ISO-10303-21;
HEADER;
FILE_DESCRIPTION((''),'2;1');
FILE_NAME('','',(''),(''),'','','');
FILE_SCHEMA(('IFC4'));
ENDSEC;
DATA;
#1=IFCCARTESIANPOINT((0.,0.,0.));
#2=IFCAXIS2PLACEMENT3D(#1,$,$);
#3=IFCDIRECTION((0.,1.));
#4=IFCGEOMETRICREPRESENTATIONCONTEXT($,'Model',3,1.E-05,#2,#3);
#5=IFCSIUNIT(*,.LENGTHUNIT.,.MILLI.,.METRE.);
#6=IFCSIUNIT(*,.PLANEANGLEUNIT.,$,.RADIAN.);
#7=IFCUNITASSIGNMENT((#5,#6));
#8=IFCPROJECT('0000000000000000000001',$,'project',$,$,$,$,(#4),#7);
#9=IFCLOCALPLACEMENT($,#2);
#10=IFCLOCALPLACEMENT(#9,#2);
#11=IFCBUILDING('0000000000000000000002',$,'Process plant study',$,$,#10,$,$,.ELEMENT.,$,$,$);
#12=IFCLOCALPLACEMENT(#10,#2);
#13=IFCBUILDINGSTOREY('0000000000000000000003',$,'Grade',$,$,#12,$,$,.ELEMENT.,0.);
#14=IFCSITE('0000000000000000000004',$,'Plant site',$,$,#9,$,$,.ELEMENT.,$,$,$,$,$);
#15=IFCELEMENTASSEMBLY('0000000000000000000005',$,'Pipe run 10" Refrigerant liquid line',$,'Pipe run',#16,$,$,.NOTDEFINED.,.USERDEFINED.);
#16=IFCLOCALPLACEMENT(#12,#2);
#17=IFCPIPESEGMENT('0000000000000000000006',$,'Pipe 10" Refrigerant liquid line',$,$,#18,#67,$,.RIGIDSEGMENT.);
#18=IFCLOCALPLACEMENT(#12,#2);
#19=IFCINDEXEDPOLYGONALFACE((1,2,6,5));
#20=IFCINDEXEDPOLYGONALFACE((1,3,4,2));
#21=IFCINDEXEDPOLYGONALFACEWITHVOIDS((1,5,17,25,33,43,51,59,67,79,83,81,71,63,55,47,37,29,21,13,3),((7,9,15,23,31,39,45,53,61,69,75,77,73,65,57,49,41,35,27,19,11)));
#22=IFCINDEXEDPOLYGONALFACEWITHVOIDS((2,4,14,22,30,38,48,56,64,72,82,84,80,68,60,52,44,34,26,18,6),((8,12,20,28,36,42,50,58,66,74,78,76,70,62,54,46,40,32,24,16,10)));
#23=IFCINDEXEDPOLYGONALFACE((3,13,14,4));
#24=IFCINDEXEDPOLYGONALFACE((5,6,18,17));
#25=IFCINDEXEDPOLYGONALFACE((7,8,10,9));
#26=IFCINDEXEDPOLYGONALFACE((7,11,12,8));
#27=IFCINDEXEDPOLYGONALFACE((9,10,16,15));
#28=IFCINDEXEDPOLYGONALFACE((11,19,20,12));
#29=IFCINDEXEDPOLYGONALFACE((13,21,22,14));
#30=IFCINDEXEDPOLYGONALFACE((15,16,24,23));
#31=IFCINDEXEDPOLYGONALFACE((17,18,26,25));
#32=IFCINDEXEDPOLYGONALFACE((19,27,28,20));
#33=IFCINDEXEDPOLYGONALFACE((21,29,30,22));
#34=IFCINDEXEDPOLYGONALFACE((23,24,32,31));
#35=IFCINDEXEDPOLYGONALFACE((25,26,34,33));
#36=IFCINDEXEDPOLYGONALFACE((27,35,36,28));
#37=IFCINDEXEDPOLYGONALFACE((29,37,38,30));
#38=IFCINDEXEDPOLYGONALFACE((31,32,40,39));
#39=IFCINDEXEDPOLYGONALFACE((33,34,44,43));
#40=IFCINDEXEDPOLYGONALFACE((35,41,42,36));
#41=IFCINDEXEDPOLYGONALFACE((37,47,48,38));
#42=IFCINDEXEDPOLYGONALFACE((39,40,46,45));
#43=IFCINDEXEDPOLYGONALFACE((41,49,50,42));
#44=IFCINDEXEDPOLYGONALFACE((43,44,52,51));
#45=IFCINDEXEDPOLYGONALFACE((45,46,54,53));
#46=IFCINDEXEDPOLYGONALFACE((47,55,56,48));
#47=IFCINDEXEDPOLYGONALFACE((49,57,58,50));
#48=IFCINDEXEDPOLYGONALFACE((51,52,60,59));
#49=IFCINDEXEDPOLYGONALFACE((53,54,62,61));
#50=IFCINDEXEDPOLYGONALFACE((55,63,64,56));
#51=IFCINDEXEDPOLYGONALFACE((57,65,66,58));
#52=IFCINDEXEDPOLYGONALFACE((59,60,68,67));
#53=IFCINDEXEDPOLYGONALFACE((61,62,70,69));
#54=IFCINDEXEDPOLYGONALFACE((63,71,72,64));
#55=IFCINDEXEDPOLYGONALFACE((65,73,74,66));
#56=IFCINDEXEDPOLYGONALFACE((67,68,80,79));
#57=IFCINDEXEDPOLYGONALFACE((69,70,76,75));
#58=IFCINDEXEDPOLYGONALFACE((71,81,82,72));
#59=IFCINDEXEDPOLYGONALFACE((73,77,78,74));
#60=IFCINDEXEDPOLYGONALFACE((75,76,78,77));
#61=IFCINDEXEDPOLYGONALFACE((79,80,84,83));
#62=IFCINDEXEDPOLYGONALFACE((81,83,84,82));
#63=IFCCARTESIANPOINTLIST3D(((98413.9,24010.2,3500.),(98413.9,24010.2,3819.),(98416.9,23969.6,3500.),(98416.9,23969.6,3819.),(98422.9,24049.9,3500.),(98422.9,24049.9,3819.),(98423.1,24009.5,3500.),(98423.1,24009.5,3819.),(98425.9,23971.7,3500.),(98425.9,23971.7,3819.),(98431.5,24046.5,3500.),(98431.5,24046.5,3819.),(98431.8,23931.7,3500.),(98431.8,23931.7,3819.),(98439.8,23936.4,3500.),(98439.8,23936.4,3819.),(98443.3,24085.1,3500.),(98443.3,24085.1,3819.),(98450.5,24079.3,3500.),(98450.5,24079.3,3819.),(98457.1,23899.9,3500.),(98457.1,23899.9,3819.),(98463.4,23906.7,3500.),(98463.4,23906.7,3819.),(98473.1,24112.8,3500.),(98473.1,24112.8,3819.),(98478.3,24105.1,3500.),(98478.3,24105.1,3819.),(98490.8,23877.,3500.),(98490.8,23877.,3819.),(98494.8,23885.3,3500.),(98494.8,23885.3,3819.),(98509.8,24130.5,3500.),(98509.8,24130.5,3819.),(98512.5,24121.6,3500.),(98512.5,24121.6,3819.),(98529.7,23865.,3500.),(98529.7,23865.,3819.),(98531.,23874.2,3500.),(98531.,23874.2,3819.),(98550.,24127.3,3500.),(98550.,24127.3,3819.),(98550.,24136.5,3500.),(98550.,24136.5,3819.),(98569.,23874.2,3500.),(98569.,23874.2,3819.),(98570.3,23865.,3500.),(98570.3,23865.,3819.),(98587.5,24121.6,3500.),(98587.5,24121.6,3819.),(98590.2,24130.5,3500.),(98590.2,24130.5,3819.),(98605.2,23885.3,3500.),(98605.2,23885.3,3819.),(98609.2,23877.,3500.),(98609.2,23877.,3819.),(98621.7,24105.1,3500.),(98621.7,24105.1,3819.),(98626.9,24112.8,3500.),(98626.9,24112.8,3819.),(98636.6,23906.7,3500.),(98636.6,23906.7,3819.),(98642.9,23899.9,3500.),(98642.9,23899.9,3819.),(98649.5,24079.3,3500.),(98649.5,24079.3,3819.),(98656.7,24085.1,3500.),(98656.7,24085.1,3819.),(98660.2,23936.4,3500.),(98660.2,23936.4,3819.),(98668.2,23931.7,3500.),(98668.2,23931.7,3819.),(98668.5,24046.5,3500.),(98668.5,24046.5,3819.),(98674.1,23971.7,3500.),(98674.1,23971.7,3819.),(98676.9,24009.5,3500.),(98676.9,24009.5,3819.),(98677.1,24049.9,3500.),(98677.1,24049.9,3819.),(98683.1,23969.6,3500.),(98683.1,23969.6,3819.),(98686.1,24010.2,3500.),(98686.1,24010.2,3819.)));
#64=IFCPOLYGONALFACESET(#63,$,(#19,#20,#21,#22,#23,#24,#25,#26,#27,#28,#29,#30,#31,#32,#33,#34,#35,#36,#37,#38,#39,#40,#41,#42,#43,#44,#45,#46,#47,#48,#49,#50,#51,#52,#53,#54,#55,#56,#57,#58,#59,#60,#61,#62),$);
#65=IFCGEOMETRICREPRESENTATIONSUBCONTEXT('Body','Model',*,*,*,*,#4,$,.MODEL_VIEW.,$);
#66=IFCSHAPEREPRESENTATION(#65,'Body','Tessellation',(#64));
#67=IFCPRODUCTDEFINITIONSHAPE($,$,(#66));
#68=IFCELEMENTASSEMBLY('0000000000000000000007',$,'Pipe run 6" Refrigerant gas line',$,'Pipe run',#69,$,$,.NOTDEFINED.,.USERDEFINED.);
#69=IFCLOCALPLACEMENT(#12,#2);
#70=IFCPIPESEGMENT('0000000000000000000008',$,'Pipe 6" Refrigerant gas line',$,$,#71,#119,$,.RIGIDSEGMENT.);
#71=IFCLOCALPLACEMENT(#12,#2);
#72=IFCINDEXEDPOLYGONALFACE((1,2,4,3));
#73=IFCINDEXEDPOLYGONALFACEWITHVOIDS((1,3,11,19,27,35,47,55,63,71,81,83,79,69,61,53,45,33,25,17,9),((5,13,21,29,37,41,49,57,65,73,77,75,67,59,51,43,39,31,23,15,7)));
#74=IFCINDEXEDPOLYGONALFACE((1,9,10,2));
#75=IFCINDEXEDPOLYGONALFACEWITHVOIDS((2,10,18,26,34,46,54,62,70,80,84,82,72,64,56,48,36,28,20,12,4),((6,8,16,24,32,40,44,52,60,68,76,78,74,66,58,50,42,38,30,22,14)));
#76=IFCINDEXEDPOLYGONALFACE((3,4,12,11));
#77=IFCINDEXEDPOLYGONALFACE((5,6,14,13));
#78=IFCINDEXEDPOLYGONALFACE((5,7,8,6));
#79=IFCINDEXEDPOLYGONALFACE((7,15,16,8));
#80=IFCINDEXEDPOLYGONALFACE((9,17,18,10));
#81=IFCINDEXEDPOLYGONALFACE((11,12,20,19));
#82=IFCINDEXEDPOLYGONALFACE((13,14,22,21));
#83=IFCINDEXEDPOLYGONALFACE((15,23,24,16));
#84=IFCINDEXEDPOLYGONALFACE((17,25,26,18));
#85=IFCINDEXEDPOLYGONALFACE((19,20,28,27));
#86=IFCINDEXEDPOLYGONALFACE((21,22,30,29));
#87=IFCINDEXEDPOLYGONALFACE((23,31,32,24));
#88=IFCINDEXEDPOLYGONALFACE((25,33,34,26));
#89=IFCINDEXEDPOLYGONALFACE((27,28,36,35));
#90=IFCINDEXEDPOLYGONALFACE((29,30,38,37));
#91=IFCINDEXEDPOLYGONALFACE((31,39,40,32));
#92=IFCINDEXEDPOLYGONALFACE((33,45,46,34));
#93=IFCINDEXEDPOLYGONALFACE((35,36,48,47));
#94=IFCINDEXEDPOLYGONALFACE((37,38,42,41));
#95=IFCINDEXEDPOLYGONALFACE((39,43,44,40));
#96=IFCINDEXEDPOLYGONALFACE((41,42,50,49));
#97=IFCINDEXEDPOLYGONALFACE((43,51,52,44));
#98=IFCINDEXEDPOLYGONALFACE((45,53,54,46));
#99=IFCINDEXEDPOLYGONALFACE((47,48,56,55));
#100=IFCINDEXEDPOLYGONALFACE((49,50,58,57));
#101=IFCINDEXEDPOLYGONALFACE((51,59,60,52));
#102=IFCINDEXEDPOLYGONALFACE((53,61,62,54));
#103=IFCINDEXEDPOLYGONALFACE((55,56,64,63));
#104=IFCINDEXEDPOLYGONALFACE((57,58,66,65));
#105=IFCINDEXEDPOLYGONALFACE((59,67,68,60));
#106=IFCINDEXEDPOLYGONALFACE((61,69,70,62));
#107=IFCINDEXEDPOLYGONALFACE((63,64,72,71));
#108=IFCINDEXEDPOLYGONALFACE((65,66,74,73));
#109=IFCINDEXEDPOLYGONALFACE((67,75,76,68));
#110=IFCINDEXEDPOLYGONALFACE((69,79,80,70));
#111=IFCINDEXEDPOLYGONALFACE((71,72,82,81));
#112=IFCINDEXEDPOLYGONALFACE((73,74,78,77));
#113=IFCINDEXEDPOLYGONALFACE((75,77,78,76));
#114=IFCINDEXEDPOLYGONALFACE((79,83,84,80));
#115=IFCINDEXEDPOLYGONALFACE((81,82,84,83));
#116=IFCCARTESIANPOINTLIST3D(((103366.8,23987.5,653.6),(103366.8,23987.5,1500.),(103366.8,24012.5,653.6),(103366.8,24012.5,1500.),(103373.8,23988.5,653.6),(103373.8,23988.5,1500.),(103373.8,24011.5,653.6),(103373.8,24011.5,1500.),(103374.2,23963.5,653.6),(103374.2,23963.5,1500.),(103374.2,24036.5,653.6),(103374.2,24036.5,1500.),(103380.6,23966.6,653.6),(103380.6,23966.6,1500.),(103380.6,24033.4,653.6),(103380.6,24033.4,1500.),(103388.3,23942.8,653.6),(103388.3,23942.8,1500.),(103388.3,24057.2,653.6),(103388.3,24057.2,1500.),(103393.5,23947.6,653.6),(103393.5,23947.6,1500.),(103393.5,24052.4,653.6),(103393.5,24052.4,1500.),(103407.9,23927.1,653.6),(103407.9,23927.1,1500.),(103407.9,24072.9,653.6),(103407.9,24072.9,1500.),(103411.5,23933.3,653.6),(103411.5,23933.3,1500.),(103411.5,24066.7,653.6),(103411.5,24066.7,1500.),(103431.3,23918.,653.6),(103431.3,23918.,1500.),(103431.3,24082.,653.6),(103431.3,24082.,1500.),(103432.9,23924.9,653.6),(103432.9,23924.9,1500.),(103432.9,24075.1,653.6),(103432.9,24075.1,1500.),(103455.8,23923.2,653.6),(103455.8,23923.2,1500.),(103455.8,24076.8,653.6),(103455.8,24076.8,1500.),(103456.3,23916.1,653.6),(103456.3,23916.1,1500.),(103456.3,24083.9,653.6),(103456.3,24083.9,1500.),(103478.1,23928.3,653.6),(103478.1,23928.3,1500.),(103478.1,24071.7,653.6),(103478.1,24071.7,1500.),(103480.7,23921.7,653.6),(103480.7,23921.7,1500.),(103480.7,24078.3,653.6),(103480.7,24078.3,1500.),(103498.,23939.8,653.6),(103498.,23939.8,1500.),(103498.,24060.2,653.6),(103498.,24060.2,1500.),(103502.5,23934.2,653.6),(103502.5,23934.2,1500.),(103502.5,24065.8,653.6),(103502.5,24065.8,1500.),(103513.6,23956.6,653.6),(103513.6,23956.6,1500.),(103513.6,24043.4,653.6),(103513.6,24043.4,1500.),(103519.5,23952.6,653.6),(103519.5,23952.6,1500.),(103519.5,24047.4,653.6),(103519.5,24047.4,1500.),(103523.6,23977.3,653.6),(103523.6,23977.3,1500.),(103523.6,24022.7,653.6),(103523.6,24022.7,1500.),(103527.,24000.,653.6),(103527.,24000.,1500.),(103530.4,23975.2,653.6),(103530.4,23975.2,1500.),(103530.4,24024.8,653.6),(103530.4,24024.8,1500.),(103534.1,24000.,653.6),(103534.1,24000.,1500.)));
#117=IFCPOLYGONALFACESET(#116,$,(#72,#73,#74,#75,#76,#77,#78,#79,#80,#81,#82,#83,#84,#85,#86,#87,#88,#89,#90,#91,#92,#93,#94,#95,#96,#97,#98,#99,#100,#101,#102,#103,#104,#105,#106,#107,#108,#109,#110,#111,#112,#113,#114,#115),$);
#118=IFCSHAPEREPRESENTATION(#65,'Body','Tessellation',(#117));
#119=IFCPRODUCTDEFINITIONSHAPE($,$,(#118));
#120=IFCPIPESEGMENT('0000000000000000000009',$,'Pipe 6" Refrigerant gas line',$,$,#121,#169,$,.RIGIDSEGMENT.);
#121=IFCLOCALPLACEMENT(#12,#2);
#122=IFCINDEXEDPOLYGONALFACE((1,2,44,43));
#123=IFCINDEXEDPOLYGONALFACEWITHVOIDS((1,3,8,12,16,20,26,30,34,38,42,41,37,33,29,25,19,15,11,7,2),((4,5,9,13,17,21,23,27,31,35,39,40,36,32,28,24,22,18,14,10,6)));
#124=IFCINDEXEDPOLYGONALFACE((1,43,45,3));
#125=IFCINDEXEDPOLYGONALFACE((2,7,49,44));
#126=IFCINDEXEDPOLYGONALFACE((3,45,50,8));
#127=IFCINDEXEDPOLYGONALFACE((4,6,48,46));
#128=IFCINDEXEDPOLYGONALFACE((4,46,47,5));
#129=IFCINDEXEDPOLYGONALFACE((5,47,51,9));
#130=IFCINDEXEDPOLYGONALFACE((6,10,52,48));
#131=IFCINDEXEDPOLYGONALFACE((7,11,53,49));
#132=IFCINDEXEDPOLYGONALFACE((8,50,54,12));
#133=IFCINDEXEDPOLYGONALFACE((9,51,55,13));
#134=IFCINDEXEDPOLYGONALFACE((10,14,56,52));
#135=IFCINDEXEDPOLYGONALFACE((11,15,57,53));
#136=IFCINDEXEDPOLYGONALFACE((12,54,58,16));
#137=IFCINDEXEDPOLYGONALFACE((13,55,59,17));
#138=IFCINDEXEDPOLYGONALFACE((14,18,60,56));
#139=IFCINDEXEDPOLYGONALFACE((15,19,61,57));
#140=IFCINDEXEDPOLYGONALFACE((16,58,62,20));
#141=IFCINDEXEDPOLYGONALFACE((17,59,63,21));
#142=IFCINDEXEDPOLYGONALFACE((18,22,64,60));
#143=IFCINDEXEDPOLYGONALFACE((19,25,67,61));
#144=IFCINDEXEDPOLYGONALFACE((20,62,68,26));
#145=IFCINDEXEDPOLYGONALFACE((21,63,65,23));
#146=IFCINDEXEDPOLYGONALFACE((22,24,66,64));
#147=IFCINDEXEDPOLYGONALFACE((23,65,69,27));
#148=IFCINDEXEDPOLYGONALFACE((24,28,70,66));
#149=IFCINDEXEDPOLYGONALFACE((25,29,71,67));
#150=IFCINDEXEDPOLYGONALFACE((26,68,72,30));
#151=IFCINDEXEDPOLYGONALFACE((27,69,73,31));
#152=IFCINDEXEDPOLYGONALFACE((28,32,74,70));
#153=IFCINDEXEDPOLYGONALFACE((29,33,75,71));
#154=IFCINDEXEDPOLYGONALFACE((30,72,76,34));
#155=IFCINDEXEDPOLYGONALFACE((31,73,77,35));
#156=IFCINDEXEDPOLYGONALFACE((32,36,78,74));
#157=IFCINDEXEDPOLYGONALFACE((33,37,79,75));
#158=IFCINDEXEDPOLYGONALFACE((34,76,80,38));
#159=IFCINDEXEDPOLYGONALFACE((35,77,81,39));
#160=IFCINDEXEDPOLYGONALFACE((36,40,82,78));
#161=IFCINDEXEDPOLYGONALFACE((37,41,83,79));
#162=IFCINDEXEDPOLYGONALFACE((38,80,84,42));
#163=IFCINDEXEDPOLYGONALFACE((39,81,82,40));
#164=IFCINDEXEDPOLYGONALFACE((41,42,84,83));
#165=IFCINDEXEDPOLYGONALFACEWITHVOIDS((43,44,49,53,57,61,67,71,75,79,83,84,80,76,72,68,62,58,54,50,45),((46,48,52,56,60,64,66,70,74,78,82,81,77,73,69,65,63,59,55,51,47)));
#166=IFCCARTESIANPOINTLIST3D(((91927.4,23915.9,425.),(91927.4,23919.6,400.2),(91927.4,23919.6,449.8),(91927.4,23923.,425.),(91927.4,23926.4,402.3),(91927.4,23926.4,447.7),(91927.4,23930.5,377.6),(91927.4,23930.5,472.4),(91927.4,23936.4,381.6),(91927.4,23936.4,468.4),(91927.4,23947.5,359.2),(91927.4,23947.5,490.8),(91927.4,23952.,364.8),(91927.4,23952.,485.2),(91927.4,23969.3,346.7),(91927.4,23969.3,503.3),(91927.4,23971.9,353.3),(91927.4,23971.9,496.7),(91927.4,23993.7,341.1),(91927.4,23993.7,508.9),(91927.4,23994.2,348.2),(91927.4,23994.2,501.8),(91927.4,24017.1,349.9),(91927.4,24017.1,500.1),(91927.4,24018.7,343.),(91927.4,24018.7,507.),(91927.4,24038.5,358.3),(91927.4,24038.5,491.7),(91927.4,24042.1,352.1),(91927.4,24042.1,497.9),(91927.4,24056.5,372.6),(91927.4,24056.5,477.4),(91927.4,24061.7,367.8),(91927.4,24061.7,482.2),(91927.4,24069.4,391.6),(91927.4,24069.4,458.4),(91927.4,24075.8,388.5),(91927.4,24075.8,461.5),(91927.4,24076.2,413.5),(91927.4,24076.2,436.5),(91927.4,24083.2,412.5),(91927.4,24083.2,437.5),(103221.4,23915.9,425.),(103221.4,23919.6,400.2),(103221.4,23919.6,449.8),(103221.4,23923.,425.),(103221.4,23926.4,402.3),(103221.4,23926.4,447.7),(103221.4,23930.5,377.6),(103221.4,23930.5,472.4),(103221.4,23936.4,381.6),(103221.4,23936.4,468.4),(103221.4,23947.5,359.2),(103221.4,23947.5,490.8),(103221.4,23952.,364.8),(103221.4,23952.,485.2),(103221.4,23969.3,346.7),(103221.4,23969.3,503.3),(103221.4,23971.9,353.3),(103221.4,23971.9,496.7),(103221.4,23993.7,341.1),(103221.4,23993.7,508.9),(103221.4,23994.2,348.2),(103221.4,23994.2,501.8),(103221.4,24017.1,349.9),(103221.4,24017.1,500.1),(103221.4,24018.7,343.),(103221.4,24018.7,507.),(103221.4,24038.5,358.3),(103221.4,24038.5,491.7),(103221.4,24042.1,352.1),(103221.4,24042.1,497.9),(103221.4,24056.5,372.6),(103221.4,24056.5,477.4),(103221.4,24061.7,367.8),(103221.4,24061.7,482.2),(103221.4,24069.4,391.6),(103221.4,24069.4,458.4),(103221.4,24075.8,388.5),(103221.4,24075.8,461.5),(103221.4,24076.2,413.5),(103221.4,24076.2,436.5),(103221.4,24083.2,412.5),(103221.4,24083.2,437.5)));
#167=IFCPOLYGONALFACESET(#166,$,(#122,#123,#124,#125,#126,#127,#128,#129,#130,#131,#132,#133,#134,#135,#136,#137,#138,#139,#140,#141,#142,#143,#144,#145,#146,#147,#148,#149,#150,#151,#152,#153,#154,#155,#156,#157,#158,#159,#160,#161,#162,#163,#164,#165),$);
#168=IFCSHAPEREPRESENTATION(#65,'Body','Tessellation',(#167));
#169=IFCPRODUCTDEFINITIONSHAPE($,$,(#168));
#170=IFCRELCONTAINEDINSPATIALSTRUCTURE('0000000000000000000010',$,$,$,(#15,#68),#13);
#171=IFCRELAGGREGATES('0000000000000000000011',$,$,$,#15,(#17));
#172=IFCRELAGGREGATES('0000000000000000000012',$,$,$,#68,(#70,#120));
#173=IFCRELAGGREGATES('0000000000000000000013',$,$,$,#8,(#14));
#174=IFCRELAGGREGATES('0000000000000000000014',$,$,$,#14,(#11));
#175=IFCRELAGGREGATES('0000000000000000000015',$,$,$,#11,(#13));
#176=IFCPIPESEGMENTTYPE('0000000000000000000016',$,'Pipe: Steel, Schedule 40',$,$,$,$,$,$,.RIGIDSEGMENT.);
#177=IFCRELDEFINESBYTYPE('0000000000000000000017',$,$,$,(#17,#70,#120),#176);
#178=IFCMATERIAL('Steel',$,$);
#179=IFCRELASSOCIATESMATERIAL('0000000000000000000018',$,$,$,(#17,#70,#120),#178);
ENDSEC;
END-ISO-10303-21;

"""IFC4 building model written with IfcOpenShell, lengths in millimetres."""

from ifc_helpers import new_model, si_unit, direction, frame, origin, origin_with_axes, origin_2d, place, context, subcontext, project, spatial, hollow_circle, extrude, material, type_object, element, aggregate, save


model = new_model("IFC4")

# Units and contexts
model_context = context("Model", 3, precision=1e-05, world=origin(), true_north=direction((0.0, 1.0)))
body_context = subcontext(model_context, "Body", "Model", "MODEL_VIEW")
ifc_project = project(units=[si_unit("LENGTHUNIT", "METRE", prefix="MILLI"), si_unit("PLANEANGLEUNIT", "RADIAN")], contexts=[model_context])

# Site, building, storey
site_placement = place(None, origin())
site = spatial("IfcSite", under=ifc_project, at=site_placement, Name="Plant site", CompositionType="ELEMENT")
building_placement = place(site_placement, origin())
building = spatial("IfcBuilding", under=site, at=building_placement, Name="Process plant study", CompositionType="ELEMENT")
storey_placement = place(building_placement, origin())
storey = spatial("IfcBuildingStorey", under=building, at=storey_placement, Name="Grade", CompositionType="ELEMENT", Elevation=0.0)

# Element assemblies, pipe segments
assembly_1_placement = place(storey_placement, origin_with_axes())
assembly_1 = element("IfcElementAssembly", 1, at=assembly_1_placement, inside=storey, Name="Pipe run 10\" Refrigerant liquid line", ObjectType="Pipe run", AssemblyPlace="NOTDEFINED", PredefinedType="USERDEFINED")
ifc_material = material(Name="Steel")
pipe_segment_type = type_object("IfcPipeSegmentType", Name="Pipe: Steel, Schedule 40", PredefinedType="RIGIDSEGMENT")
pipe_segment_1_placement = place(storey_placement, origin_with_axes())
pipe_segment_1 = element("IfcPipeSegment", 2, at=pipe_segment_1_placement, type_object=pipe_segment_type, material=ifc_material, Name="Pipe 10\" Refrigerant liquid line", PredefinedType="RIGIDSEGMENT", context=body_context, shape_type="SweptSolid", body=[
    extrude(hollow_circle(Radius=136.5, WallThickness=9.3, at=origin_2d()), frame((98550.0, 24000.0, 3819.0), z_axis=(0.0, 0.0, -1.0), x_axis=(0.0, 1.0, 0.0)), (0.0, 0.0, 1.0), 319.0),
])
assembly_2_placement = place(storey_placement, origin_with_axes())
assembly_2 = element("IfcElementAssembly", 3, at=assembly_2_placement, inside=storey, Name="Pipe run 6\" Refrigerant gas line", ObjectType="Pipe run", AssemblyPlace="NOTDEFINED", PredefinedType="USERDEFINED")
pipe_segment_2_placement = place(storey_placement, origin_with_axes())
pipe_segment_2 = element("IfcPipeSegment", 4, at=pipe_segment_2_placement, type_object=pipe_segment_type, material=ifc_material, Name="Pipe 6\" Refrigerant gas line", PredefinedType="RIGIDSEGMENT", context=body_context, shape_type="SweptSolid", body=[
    extrude(hollow_circle(Radius=84.1, WallThickness=7.1, at=origin_2d()), frame((103450.0, 24000.0, 1500.0), z_axis=(0.0, 0.0, -1.0), x_axis=(1.0, 0.0, 0.0)), (0.0, 0.0, 1.0), 846.4),
])
pipe_segment_3_placement = place(storey_placement, origin_with_axes())
pipe_segment_3 = element("IfcPipeSegment", 5, at=pipe_segment_3_placement, type_object=pipe_segment_type, material=ifc_material, Name="Pipe 6\" Refrigerant gas line", PredefinedType="RIGIDSEGMENT", context=body_context, shape_type="SweptSolid", body=[
    extrude(hollow_circle(Radius=84.1, WallThickness=7.1, at=origin_2d()), frame((103221.4, 24000.0, 425.0), z_axis=(-1.0, 0.0, 0.0), x_axis=(0.0, -1.0, 0.0)), (0.0, 0.0, 1.0), 11294.0),
])

aggregate(assembly_1, [pipe_segment_1])
aggregate(assembly_2, [pipe_segment_2, pipe_segment_3])

save(model, "model.ifc")
